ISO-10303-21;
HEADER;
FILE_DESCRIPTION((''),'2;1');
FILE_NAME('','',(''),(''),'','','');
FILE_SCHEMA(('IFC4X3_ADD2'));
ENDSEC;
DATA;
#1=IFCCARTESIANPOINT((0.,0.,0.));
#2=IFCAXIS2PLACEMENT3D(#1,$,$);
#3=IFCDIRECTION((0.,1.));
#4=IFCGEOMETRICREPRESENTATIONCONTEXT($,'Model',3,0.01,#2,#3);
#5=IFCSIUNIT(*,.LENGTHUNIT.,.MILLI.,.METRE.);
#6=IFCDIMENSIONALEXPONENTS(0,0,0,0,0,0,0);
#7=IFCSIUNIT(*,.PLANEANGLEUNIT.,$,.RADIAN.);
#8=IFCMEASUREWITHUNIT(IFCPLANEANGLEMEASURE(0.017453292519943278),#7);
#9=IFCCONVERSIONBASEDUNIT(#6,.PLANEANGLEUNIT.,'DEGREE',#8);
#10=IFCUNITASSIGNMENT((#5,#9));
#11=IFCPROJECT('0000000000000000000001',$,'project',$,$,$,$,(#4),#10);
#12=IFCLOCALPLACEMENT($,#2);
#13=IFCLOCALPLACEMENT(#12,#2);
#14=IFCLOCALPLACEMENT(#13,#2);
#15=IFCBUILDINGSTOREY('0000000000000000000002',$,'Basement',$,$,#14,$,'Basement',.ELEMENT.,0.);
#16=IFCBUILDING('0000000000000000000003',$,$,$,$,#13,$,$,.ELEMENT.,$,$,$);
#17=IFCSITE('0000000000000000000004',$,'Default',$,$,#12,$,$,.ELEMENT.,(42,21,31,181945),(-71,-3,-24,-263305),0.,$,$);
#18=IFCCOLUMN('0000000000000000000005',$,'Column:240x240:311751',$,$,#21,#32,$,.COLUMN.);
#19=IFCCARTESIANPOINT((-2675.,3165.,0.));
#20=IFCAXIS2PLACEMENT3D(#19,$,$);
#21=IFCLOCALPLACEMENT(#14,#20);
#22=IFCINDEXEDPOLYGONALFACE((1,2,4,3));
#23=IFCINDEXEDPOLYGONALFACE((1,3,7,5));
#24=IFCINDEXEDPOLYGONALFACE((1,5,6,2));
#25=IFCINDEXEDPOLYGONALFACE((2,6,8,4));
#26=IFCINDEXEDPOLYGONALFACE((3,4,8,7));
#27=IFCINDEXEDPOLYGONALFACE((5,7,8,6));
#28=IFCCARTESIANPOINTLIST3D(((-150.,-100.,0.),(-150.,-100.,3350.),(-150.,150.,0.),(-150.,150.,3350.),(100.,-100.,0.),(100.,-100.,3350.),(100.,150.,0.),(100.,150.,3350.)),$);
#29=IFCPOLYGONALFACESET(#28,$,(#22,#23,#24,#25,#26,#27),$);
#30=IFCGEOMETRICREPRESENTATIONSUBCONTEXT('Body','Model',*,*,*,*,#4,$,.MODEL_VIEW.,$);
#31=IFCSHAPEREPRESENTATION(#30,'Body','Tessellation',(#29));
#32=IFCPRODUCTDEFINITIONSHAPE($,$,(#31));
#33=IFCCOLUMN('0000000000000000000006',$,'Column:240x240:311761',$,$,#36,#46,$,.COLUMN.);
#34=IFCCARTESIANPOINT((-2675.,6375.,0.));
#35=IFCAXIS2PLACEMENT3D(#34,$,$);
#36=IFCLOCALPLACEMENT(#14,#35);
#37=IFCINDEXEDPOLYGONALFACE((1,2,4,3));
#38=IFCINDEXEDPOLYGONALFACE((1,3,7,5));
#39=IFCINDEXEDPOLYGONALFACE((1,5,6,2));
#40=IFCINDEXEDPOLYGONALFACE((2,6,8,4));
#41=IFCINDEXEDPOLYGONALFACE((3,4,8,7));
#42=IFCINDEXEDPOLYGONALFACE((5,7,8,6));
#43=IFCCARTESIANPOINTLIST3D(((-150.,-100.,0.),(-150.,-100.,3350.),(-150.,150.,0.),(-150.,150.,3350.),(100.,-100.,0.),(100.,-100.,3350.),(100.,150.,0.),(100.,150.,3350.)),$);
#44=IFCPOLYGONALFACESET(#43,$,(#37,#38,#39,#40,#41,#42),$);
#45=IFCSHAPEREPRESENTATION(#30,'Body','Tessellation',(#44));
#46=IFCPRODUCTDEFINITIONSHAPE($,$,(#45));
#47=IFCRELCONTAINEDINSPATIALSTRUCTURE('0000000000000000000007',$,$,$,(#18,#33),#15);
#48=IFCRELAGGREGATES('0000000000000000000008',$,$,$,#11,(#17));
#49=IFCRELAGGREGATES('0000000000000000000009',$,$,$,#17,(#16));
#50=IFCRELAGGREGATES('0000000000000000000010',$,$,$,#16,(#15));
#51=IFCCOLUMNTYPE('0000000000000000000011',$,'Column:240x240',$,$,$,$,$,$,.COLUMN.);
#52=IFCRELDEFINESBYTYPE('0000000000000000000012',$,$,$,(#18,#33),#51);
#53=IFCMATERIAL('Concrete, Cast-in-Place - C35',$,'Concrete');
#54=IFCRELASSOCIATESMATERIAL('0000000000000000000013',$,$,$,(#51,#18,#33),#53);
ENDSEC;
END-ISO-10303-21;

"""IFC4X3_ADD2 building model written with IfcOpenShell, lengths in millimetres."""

from ifc_helpers import new_model, entity, si_unit, converted_unit, direction, frame, origin, origin_2d_with_axis, place, context, subcontext, project, spatial, rectangle, extrude, source, transform, mapped, material, material_profile, profile_set, profile_usage, type_object, type_shapes, element, save


model = new_model("IFC4X3_ADD2")

# Units and contexts
model_context = context("Model", 3, precision=0.01, world=origin(), true_north=direction((0.0, 1.0)))
body_context = subcontext(model_context, "Body", "Model", "MODEL_VIEW")
ifc_project = project(units=[si_unit("LENGTHUNIT", "METRE", prefix="MILLI"), converted_unit("PLANEANGLEUNIT", "DEGREE", entity("IfcPlaneAngleMeasure", 0.017453292519943278), si_unit("PLANEANGLEUNIT", "RADIAN"), dimensions=[0, 0, 0, 0, 0, 0, 0])], contexts=[model_context])

# Site, building, storey
site_placement = place(None, origin())
site = spatial("IfcSite", under=ifc_project, at=site_placement, Name="Default", CompositionType="ELEMENT", RefLatitude=(42, 21, 31, 181945), RefLongitude=(-71, -3, -24, -263305), RefElevation=0.0)
building_placement = place(site_placement, origin())
building = spatial("IfcBuilding", under=site, at=building_placement, CompositionType="ELEMENT")
storey_placement = place(building_placement, origin())
storey = spatial("IfcBuildingStorey", under=building, at=storey_placement, Name="Basement", LongName="Basement", CompositionType="ELEMENT", Elevation=0.0)

# Columns
ifc_material = material(Name="Concrete, Cast-in-Place - C35", Category="Concrete")
ifc_material_profile_1 = material_profile(ifc_material, rectangle(XDim=250.0, YDim=250.0, at=origin_2d_with_axis()), Name="240x240")
ifc_profile_set_1 = profile_set([ifc_material_profile_1], Name="240x240")
ifc_profile_usage_1 = profile_usage(ifc_profile_set_1)
column_type_1 = type_object("IfcColumnType", Name="Column:240x240", PredefinedType="COLUMN", material=ifc_profile_set_1)
shared_shape_1 = source(origin(), body_context, "Body", "SweptSolid", [
    extrude(rectangle(XDim=250.0, YDim=250.0, at=origin_2d_with_axis()), frame((-25.0, 25.0, 0.0), z_axis=(0.0, 0.0, 1.0), x_axis=(-1.0, 0.0, 0.0)), (0.0, 0.0, 1.0), 3350.0),
])
type_shapes(column_type_1, [shared_shape_1])
for number, where, name in (
    (1, (-2675.0, 3165.0, 0.0), "Column:240x240:311751"),
    (2, (-2675.0, 6375.0, 0.0), "Column:240x240:311761"),
):
    element("IfcColumn", number, at=place(storey_placement, frame(where)), inside=storey, type_object=column_type_1, material=ifc_profile_usage_1, Name=name, PredefinedType="COLUMN", context=body_context, shape_type="MappedRepresentation", body=[
        mapped(shared_shape_1, transform((0.0, 0.0, 0.0), scale=1.0)),
    ])

save(model, "model.ifc")
